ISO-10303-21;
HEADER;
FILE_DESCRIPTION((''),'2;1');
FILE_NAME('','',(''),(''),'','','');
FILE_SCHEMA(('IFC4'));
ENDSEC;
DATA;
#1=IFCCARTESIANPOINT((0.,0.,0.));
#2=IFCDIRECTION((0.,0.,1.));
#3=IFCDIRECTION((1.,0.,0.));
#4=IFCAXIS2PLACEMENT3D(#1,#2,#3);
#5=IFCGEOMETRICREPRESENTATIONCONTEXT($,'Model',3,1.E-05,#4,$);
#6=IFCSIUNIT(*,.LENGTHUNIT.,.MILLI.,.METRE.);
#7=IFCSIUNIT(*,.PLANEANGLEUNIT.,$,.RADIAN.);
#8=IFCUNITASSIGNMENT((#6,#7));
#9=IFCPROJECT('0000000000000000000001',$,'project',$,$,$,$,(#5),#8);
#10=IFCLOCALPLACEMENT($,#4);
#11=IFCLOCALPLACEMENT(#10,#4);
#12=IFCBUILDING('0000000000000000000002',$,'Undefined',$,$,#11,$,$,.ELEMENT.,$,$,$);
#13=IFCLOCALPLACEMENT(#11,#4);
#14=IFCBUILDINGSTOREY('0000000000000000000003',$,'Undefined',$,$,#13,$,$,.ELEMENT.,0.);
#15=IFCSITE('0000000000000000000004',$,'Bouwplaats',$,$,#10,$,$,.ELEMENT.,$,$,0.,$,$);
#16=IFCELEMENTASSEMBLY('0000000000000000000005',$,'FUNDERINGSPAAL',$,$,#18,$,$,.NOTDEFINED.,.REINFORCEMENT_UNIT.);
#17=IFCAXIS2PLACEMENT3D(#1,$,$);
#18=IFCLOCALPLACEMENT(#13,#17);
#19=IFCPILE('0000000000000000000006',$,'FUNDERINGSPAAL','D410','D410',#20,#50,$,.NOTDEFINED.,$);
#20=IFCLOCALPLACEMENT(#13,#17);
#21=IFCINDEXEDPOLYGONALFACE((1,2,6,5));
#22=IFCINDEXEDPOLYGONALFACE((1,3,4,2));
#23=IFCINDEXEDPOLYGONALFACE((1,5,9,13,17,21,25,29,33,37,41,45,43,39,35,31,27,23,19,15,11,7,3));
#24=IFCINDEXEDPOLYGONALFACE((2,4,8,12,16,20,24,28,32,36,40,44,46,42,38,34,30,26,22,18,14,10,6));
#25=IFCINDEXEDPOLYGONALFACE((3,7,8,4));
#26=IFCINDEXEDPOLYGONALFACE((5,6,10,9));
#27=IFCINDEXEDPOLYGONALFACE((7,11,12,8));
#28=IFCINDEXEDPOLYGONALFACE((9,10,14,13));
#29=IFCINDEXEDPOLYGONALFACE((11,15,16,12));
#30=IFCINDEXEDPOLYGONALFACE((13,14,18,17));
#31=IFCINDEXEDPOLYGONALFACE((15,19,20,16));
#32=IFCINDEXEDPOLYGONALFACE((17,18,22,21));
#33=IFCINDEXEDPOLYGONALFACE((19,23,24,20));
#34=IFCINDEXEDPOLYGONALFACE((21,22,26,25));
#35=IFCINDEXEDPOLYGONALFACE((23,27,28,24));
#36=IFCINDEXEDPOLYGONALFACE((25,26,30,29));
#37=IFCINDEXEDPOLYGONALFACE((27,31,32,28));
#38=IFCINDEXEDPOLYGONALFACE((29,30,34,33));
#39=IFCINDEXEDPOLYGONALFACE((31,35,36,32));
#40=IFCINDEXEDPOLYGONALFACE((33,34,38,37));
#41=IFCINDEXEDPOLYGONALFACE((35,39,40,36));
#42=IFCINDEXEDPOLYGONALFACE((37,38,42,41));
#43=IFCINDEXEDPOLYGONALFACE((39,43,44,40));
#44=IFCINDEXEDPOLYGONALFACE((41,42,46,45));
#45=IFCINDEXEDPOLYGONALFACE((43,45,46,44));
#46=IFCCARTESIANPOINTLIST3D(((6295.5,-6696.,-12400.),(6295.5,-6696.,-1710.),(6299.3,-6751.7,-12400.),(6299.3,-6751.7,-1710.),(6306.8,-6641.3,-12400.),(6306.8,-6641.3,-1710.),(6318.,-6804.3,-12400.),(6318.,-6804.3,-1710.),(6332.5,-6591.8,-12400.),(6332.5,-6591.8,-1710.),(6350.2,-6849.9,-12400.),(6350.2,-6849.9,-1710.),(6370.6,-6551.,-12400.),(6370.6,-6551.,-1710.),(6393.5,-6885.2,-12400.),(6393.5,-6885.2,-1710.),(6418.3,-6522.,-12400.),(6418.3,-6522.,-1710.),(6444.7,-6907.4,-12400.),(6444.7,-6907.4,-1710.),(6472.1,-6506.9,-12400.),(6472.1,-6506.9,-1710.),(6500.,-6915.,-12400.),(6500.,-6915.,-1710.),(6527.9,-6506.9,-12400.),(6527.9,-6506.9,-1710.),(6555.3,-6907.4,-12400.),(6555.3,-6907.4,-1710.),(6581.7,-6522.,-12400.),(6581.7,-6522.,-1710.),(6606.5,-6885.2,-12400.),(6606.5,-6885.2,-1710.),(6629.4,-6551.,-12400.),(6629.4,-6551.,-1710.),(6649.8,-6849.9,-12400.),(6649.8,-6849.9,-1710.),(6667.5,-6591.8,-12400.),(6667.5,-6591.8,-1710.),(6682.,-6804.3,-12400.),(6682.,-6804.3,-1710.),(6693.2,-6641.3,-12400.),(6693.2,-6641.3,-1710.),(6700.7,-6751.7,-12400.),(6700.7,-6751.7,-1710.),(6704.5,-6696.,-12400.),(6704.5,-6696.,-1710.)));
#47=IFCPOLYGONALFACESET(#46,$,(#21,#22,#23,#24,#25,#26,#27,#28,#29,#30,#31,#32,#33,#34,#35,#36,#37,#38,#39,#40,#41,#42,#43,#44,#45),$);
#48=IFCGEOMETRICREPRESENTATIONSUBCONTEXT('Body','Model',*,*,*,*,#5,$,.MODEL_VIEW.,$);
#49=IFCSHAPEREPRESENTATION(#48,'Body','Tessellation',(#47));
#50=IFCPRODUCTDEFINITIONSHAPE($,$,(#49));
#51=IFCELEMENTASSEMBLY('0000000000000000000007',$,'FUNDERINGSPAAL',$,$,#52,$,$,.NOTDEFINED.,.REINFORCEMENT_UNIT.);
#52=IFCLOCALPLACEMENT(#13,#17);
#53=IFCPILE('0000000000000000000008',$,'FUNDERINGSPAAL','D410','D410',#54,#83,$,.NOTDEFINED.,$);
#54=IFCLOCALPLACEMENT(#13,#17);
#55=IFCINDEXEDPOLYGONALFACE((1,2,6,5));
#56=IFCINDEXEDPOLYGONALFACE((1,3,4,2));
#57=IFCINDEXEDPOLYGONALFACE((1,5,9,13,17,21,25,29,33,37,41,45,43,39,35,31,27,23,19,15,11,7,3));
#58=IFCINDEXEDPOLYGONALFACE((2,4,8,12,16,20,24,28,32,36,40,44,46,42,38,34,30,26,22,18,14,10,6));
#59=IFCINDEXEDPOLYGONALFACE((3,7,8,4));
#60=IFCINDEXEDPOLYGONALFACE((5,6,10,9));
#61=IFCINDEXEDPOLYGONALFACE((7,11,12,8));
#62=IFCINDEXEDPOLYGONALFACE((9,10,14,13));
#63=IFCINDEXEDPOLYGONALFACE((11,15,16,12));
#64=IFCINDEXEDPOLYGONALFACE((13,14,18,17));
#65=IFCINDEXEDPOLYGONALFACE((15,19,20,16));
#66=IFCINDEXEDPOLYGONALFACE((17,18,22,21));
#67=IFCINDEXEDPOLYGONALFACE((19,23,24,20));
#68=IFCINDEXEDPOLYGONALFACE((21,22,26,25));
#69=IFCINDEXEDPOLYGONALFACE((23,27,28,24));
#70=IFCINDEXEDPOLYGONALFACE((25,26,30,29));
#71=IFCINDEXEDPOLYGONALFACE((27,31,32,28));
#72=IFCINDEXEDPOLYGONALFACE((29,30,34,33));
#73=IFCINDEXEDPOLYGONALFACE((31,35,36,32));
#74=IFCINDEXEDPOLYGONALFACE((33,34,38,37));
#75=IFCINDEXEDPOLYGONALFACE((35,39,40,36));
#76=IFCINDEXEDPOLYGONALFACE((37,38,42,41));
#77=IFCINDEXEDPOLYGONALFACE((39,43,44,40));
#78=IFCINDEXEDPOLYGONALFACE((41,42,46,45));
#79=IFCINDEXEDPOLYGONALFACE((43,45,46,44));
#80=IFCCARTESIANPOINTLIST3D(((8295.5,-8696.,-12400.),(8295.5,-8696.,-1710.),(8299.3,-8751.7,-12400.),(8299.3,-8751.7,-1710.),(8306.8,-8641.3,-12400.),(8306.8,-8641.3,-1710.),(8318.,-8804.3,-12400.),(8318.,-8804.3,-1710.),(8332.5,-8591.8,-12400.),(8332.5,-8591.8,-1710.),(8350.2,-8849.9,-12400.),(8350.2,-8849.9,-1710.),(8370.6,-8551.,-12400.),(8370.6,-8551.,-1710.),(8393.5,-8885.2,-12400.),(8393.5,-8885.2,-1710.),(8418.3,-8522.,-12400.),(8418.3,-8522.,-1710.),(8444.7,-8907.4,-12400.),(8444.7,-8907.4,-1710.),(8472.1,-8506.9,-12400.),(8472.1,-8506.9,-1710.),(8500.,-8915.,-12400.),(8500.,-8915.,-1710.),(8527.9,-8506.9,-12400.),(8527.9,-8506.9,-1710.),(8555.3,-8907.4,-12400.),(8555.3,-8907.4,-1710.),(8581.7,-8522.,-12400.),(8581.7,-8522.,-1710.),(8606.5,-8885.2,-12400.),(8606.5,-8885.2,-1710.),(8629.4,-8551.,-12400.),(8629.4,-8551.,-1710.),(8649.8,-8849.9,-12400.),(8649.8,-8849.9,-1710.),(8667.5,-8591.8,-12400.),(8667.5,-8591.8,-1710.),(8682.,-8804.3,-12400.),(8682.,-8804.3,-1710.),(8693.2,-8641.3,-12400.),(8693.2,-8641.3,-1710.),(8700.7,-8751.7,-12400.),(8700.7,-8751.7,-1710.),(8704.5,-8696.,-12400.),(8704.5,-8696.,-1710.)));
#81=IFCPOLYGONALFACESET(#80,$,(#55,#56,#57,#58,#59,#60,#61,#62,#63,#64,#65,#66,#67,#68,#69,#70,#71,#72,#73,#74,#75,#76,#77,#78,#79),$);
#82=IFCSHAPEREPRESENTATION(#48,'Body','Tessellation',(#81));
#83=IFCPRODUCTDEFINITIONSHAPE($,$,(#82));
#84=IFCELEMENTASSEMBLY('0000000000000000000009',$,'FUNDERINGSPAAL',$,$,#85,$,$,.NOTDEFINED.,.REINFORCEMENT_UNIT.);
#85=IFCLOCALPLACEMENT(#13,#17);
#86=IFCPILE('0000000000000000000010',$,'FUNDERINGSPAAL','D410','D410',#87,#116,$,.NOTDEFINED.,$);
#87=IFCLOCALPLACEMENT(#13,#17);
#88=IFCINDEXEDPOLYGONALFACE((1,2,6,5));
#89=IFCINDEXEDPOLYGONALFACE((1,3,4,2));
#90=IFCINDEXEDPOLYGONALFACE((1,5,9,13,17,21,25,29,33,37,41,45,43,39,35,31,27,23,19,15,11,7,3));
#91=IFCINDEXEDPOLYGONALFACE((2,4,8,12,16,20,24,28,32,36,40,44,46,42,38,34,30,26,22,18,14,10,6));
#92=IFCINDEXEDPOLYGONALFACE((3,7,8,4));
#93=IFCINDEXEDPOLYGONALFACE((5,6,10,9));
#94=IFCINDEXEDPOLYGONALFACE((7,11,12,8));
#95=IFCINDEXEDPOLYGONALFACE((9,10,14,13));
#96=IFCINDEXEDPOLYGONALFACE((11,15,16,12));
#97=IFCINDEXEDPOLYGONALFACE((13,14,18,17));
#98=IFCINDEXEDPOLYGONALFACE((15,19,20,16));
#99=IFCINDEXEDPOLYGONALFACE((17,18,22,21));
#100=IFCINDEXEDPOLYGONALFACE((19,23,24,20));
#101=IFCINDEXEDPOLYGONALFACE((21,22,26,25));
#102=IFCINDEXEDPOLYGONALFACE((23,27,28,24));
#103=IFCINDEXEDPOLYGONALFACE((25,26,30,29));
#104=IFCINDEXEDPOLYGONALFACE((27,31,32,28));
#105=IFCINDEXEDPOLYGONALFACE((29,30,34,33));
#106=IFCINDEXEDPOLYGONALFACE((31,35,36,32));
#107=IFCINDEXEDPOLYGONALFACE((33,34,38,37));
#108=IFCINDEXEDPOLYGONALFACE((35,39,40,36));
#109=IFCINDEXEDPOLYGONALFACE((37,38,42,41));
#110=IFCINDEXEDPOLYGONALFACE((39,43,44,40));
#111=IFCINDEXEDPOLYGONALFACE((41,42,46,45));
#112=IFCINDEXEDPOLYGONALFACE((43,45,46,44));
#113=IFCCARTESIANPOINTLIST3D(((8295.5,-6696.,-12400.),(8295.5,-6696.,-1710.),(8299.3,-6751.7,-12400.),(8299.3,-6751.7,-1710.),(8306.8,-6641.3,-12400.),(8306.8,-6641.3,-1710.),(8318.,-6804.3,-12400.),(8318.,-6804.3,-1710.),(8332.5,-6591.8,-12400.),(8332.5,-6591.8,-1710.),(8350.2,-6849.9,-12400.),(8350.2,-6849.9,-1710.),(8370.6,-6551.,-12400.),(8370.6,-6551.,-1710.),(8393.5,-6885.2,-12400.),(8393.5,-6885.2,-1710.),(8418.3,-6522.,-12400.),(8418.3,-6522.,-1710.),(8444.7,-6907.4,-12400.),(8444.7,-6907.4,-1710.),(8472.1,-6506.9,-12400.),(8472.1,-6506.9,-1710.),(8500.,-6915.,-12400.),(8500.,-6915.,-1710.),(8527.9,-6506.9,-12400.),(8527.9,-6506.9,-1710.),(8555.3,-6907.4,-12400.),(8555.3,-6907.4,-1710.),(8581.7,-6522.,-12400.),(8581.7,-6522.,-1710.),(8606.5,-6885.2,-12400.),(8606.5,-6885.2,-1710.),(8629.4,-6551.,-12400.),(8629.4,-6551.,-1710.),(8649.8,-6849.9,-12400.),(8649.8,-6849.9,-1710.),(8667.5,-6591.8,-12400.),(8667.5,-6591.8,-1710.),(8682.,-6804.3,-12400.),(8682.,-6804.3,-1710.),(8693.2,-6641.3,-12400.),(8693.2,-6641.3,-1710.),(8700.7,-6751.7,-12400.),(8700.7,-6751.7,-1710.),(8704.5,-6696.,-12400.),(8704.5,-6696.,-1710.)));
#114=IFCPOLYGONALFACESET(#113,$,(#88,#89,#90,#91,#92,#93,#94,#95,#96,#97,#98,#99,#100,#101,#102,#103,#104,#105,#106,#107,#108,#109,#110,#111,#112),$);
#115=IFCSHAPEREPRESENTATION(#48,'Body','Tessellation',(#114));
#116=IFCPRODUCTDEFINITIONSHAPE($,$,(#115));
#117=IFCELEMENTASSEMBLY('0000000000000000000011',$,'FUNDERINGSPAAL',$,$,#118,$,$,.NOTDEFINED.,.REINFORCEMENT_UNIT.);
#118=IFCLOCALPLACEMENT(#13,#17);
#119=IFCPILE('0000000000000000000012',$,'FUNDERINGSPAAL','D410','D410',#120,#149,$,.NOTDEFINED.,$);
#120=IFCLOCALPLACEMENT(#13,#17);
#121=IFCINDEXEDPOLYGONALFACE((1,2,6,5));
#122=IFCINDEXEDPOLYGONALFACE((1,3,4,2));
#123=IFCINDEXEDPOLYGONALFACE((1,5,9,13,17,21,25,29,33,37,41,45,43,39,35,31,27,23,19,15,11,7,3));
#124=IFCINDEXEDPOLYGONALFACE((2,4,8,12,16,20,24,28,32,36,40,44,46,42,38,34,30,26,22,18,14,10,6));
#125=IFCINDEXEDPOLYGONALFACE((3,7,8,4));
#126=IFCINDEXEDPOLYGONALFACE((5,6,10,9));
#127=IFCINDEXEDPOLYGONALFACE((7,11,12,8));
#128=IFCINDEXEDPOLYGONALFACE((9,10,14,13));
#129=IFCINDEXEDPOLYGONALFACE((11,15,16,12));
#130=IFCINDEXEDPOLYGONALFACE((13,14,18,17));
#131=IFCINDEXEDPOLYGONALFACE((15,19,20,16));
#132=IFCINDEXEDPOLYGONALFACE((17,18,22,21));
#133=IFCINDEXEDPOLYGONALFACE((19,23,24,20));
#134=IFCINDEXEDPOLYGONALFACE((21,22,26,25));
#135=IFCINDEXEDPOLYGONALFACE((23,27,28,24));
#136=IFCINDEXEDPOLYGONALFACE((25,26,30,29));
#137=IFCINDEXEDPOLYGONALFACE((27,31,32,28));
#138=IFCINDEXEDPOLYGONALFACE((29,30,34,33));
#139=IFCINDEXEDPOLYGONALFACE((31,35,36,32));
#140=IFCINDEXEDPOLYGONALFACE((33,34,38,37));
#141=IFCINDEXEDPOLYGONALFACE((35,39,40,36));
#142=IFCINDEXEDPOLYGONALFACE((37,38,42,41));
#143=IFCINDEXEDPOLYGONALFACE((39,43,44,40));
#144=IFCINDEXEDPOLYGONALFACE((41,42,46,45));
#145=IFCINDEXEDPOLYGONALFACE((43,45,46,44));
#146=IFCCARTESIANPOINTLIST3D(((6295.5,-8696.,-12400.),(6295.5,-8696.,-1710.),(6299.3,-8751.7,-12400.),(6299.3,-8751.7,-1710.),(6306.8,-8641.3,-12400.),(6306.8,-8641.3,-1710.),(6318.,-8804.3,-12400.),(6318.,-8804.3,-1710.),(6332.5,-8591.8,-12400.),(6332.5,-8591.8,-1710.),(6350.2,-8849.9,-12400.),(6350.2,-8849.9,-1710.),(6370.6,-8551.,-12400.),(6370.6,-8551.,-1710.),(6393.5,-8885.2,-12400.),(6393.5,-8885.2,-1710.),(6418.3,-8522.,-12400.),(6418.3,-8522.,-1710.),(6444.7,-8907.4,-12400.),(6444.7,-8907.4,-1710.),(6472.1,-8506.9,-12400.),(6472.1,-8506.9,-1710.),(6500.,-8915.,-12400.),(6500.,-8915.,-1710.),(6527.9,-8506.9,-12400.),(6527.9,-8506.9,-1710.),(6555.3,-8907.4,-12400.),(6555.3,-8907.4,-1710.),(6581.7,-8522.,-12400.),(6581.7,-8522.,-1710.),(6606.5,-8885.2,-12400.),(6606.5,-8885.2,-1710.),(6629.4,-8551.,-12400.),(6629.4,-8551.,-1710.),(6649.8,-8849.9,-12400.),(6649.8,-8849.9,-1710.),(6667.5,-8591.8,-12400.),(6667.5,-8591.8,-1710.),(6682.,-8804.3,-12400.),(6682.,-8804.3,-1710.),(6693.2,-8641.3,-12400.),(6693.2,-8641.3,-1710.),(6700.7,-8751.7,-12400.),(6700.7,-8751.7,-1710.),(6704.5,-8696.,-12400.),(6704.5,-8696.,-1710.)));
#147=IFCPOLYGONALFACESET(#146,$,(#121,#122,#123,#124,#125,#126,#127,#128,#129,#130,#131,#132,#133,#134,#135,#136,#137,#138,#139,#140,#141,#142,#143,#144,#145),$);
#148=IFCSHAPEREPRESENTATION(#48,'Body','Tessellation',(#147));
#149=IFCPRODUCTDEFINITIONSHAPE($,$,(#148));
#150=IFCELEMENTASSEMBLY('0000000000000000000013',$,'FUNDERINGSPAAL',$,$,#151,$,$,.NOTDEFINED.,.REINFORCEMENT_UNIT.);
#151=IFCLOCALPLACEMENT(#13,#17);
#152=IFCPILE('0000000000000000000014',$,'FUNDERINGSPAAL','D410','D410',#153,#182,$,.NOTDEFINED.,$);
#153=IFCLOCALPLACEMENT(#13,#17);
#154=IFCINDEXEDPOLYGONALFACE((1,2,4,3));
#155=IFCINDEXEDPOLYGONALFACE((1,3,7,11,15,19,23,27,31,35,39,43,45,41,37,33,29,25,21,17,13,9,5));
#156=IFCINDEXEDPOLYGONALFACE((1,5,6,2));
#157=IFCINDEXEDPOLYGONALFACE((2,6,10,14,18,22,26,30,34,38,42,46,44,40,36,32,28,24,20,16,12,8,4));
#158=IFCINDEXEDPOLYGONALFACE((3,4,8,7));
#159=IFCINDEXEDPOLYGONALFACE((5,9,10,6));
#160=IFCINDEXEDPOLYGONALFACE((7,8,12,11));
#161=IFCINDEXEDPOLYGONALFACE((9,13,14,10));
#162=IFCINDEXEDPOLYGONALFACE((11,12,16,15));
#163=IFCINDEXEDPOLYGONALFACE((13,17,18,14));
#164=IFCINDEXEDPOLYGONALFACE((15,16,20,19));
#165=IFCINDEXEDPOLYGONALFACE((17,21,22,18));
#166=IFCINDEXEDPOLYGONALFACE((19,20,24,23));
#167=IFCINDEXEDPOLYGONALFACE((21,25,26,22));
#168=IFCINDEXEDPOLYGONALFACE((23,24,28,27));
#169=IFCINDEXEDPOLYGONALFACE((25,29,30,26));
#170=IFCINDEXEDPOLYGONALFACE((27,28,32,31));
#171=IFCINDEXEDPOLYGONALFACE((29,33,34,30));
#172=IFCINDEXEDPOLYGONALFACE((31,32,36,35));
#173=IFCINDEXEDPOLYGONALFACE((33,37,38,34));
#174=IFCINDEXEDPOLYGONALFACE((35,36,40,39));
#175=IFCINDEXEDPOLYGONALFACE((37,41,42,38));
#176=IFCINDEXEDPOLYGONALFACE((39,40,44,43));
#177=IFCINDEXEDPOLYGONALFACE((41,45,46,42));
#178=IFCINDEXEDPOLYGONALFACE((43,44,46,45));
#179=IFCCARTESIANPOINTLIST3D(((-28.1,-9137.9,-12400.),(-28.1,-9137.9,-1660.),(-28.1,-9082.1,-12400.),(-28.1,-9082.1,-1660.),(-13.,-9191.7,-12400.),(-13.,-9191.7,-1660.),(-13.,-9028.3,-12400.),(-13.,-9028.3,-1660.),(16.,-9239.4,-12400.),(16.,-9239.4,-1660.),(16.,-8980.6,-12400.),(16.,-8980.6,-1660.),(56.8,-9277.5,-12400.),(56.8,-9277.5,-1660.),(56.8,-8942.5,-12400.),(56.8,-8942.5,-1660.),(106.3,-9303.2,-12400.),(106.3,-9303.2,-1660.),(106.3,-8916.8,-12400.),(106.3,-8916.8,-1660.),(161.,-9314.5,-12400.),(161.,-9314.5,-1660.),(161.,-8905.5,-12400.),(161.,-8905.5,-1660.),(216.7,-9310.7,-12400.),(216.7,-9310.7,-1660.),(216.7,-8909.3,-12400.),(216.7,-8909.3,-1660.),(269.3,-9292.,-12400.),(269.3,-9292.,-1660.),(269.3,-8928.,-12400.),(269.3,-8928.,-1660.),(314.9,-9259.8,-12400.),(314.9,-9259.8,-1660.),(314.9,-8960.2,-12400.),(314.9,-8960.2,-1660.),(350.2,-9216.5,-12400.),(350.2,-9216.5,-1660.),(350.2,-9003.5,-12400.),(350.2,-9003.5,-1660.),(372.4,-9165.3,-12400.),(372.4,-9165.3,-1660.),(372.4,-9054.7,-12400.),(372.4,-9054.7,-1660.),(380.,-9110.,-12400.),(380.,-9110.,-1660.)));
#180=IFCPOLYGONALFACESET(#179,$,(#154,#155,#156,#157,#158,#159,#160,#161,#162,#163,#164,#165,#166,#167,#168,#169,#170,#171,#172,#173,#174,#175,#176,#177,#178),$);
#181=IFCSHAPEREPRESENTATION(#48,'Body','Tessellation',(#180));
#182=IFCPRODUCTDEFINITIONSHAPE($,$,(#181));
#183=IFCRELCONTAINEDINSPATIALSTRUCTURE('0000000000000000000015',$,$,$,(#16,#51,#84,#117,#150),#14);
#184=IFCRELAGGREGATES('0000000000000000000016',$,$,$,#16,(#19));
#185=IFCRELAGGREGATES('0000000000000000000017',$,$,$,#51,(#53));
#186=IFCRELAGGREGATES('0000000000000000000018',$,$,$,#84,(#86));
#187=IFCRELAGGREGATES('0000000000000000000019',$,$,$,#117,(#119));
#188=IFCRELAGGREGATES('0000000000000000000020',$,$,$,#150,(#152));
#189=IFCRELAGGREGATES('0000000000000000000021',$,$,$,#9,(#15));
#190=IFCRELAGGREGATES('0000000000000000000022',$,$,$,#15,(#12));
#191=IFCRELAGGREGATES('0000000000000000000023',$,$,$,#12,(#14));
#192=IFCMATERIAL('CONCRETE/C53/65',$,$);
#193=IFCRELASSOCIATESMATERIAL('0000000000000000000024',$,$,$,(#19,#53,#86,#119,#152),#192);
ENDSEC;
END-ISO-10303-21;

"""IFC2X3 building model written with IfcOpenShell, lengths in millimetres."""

from ifc_helpers import new_model, si_unit, frame, origin_with_axes, origin_2d_with_axis, place, context, subcontext, project, spatial, circle, extrude, clip, halfspace, material, element, aggregate, save


model = new_model("IFC2X3")

# Units and contexts
model_context = context("Model", 3, precision=1e-05, world=origin_with_axes())
body_context = subcontext(model_context, "Body", "Model", "MODEL_VIEW")
ifc_project = project(units=[si_unit("LENGTHUNIT", "METRE", prefix="MILLI"), si_unit("PLANEANGLEUNIT", "RADIAN")], contexts=[model_context])

# Site, building, storey
site_placement = place(None, origin_with_axes())
site = spatial("IfcSite", under=ifc_project, at=site_placement, Name="Bouwplaats", CompositionType="ELEMENT", RefElevation=0.0)
building_placement = place(site_placement, origin_with_axes())
building = spatial("IfcBuilding", under=site, at=building_placement, Name="Undefined", CompositionType="ELEMENT")
storey_placement = place(building_placement, origin_with_axes())
storey = spatial("IfcBuildingStorey", under=building, at=storey_placement, Name="Undefined", CompositionType="ELEMENT", Elevation=0.0)

# Element assemblies, piles
ifc_material_1 = material(Name="CONCRETE/C53/65")
assembly_1_placement = place(storey_placement, origin_with_axes())
assembly_1 = element("IfcElementAssembly", 1, at=assembly_1_placement, inside=storey, Name="FUNDERINGSPAAL", AssemblyPlace="NOTDEFINED", PredefinedType="REINFORCEMENT_UNIT")
pile_1_placement = place(assembly_1_placement, frame((6500.0, -6710.0, -1710.0), z_axis=(1.0, 0.0, 0.0), x_axis=(0.0, 0.0, -1.0)))
pile_1 = element("IfcPile", 2, at=pile_1_placement, material=ifc_material_1, Name="FUNDERINGSPAAL", Description="D410", ObjectType="D410", PredefinedType="NOTDEFINED", context=body_context, shape_type="Clipping", body=[
    clip(extrude(circle(Radius=205.0, at=origin_2d_with_axis()), frame((10690.0, 0.0, 0.0), z_axis=(-1.0, 0.0, 0.0), x_axis=(0.0, -1.0, 0.0)), (0.0, 0.0, 1.0), 10690.0), halfspace(frame((0.0, 205.0, -205.0), z_axis=(-1.0, 0.0, 0.0), x_axis=(0.0, 0.0, 1.0)), False)),
])
aggregate(assembly_1, [pile_1])
assembly_2_placement = place(storey_placement, origin_with_axes())
assembly_2 = element("IfcElementAssembly", 3, at=assembly_2_placement, inside=storey, Name="FUNDERINGSPAAL", AssemblyPlace="NOTDEFINED", PredefinedType="REINFORCEMENT_UNIT")
pile_2_placement = place(assembly_2_placement, frame((8500.0, -8710.0, -1710.0), z_axis=(1.0, 0.0, 0.0), x_axis=(0.0, 0.0, -1.0)))
pile_2 = element("IfcPile", 4, at=pile_2_placement, material=ifc_material_1, Name="FUNDERINGSPAAL", Description="D410", ObjectType="D410", PredefinedType="NOTDEFINED", context=body_context, shape_type="Clipping", body=[
    clip(extrude(circle(Radius=205.0, at=origin_2d_with_axis()), frame((10690.0, 0.0, 0.0), z_axis=(-1.0, 0.0, 0.0), x_axis=(0.0, -1.0, 0.0)), (0.0, 0.0, 1.0), 10690.0), halfspace(frame((0.0, 205.0, -205.0), z_axis=(-1.0, 0.0, 0.0), x_axis=(0.0, 0.0, 1.0)), False)),
])
aggregate(assembly_2, [pile_2])
assembly_3_placement = place(storey_placement, origin_with_axes())
assembly_3 = element("IfcElementAssembly", 5, at=assembly_3_placement, inside=storey, Name="FUNDERINGSPAAL", AssemblyPlace="NOTDEFINED", PredefinedType="REINFORCEMENT_UNIT")
pile_3_placement = place(assembly_3_placement, frame((8500.0, -6710.0, -1710.0), z_axis=(1.0, 0.0, 0.0), x_axis=(0.0, 0.0, -1.0)))
pile_3 = element("IfcPile", 6, at=pile_3_placement, material=ifc_material_1, Name="FUNDERINGSPAAL", Description="D410", ObjectType="D410", PredefinedType="NOTDEFINED", context=body_context, shape_type="Clipping", body=[
    clip(extrude(circle(Radius=205.0, at=origin_2d_with_axis()), frame((10690.0, 0.0, 0.0), z_axis=(-1.0, 0.0, 0.0), x_axis=(0.0, -1.0, 0.0)), (0.0, 0.0, 1.0), 10690.0), halfspace(frame((0.0, 205.0, -205.0), z_axis=(-1.0, 0.0, 0.0), x_axis=(0.0, 0.0, 1.0)), False)),
])
aggregate(assembly_3, [pile_3])
assembly_4_placement = place(storey_placement, origin_with_axes())
assembly_4 = element("IfcElementAssembly", 7, at=assembly_4_placement, inside=storey, Name="FUNDERINGSPAAL", AssemblyPlace="NOTDEFINED", PredefinedType="REINFORCEMENT_UNIT")
pile_4_placement = place(assembly_4_placement, frame((6500.0, -8710.0, -1710.0), z_axis=(1.0, 0.0, 0.0), x_axis=(0.0, 0.0, -1.0)))
pile_4 = element("IfcPile", 8, at=pile_4_placement, material=ifc_material_1, Name="FUNDERINGSPAAL", Description="D410", ObjectType="D410", PredefinedType="NOTDEFINED", context=body_context, shape_type="Clipping", body=[
    clip(extrude(circle(Radius=205.0, at=origin_2d_with_axis()), frame((10690.0, 0.0, 0.0), z_axis=(-1.0, 0.0, 0.0), x_axis=(0.0, -1.0, 0.0)), (0.0, 0.0, 1.0), 10690.0), halfspace(frame((0.0, 205.0, -205.0), z_axis=(-1.0, 0.0, 0.0), x_axis=(0.0, 0.0, 1.0)), False)),
])
aggregate(assembly_4, [pile_4])
assembly_5_placement = place(storey_placement, origin_with_axes())
assembly_5 = element("IfcElementAssembly", 9, at=assembly_5_placement, inside=storey, Name="FUNDERINGSPAAL", AssemblyPlace="NOTDEFINED", PredefinedType="REINFORCEMENT_UNIT")
pile_5_placement = place(assembly_5_placement, frame((175.0, -9110.0, -1660.0), z_axis=(0.0, 1.0, 0.0), x_axis=(0.0, 0.0, -1.0)))
pile_5 = element("IfcPile", 10, at=pile_5_placement, material=ifc_material_1, Name="FUNDERINGSPAAL", Description="D410", ObjectType="D410", PredefinedType="NOTDEFINED", context=body_context, shape_type="Clipping", body=[
    clip(extrude(circle(Radius=205.0, at=origin_2d_with_axis()), frame((10740.0, 0.0, 0.0), z_axis=(-1.0, 0.0, 0.0), x_axis=(0.0, -1.0, 0.0)), (0.0, 0.0, 1.0), 10740.0), halfspace(frame((0.0, 205.0, -205.0), z_axis=(-1.0, 0.0, 0.0), x_axis=(0.0, 0.0, 1.0)), False)),
])
aggregate(assembly_5, [pile_5])

save(model, "model.ifc")
